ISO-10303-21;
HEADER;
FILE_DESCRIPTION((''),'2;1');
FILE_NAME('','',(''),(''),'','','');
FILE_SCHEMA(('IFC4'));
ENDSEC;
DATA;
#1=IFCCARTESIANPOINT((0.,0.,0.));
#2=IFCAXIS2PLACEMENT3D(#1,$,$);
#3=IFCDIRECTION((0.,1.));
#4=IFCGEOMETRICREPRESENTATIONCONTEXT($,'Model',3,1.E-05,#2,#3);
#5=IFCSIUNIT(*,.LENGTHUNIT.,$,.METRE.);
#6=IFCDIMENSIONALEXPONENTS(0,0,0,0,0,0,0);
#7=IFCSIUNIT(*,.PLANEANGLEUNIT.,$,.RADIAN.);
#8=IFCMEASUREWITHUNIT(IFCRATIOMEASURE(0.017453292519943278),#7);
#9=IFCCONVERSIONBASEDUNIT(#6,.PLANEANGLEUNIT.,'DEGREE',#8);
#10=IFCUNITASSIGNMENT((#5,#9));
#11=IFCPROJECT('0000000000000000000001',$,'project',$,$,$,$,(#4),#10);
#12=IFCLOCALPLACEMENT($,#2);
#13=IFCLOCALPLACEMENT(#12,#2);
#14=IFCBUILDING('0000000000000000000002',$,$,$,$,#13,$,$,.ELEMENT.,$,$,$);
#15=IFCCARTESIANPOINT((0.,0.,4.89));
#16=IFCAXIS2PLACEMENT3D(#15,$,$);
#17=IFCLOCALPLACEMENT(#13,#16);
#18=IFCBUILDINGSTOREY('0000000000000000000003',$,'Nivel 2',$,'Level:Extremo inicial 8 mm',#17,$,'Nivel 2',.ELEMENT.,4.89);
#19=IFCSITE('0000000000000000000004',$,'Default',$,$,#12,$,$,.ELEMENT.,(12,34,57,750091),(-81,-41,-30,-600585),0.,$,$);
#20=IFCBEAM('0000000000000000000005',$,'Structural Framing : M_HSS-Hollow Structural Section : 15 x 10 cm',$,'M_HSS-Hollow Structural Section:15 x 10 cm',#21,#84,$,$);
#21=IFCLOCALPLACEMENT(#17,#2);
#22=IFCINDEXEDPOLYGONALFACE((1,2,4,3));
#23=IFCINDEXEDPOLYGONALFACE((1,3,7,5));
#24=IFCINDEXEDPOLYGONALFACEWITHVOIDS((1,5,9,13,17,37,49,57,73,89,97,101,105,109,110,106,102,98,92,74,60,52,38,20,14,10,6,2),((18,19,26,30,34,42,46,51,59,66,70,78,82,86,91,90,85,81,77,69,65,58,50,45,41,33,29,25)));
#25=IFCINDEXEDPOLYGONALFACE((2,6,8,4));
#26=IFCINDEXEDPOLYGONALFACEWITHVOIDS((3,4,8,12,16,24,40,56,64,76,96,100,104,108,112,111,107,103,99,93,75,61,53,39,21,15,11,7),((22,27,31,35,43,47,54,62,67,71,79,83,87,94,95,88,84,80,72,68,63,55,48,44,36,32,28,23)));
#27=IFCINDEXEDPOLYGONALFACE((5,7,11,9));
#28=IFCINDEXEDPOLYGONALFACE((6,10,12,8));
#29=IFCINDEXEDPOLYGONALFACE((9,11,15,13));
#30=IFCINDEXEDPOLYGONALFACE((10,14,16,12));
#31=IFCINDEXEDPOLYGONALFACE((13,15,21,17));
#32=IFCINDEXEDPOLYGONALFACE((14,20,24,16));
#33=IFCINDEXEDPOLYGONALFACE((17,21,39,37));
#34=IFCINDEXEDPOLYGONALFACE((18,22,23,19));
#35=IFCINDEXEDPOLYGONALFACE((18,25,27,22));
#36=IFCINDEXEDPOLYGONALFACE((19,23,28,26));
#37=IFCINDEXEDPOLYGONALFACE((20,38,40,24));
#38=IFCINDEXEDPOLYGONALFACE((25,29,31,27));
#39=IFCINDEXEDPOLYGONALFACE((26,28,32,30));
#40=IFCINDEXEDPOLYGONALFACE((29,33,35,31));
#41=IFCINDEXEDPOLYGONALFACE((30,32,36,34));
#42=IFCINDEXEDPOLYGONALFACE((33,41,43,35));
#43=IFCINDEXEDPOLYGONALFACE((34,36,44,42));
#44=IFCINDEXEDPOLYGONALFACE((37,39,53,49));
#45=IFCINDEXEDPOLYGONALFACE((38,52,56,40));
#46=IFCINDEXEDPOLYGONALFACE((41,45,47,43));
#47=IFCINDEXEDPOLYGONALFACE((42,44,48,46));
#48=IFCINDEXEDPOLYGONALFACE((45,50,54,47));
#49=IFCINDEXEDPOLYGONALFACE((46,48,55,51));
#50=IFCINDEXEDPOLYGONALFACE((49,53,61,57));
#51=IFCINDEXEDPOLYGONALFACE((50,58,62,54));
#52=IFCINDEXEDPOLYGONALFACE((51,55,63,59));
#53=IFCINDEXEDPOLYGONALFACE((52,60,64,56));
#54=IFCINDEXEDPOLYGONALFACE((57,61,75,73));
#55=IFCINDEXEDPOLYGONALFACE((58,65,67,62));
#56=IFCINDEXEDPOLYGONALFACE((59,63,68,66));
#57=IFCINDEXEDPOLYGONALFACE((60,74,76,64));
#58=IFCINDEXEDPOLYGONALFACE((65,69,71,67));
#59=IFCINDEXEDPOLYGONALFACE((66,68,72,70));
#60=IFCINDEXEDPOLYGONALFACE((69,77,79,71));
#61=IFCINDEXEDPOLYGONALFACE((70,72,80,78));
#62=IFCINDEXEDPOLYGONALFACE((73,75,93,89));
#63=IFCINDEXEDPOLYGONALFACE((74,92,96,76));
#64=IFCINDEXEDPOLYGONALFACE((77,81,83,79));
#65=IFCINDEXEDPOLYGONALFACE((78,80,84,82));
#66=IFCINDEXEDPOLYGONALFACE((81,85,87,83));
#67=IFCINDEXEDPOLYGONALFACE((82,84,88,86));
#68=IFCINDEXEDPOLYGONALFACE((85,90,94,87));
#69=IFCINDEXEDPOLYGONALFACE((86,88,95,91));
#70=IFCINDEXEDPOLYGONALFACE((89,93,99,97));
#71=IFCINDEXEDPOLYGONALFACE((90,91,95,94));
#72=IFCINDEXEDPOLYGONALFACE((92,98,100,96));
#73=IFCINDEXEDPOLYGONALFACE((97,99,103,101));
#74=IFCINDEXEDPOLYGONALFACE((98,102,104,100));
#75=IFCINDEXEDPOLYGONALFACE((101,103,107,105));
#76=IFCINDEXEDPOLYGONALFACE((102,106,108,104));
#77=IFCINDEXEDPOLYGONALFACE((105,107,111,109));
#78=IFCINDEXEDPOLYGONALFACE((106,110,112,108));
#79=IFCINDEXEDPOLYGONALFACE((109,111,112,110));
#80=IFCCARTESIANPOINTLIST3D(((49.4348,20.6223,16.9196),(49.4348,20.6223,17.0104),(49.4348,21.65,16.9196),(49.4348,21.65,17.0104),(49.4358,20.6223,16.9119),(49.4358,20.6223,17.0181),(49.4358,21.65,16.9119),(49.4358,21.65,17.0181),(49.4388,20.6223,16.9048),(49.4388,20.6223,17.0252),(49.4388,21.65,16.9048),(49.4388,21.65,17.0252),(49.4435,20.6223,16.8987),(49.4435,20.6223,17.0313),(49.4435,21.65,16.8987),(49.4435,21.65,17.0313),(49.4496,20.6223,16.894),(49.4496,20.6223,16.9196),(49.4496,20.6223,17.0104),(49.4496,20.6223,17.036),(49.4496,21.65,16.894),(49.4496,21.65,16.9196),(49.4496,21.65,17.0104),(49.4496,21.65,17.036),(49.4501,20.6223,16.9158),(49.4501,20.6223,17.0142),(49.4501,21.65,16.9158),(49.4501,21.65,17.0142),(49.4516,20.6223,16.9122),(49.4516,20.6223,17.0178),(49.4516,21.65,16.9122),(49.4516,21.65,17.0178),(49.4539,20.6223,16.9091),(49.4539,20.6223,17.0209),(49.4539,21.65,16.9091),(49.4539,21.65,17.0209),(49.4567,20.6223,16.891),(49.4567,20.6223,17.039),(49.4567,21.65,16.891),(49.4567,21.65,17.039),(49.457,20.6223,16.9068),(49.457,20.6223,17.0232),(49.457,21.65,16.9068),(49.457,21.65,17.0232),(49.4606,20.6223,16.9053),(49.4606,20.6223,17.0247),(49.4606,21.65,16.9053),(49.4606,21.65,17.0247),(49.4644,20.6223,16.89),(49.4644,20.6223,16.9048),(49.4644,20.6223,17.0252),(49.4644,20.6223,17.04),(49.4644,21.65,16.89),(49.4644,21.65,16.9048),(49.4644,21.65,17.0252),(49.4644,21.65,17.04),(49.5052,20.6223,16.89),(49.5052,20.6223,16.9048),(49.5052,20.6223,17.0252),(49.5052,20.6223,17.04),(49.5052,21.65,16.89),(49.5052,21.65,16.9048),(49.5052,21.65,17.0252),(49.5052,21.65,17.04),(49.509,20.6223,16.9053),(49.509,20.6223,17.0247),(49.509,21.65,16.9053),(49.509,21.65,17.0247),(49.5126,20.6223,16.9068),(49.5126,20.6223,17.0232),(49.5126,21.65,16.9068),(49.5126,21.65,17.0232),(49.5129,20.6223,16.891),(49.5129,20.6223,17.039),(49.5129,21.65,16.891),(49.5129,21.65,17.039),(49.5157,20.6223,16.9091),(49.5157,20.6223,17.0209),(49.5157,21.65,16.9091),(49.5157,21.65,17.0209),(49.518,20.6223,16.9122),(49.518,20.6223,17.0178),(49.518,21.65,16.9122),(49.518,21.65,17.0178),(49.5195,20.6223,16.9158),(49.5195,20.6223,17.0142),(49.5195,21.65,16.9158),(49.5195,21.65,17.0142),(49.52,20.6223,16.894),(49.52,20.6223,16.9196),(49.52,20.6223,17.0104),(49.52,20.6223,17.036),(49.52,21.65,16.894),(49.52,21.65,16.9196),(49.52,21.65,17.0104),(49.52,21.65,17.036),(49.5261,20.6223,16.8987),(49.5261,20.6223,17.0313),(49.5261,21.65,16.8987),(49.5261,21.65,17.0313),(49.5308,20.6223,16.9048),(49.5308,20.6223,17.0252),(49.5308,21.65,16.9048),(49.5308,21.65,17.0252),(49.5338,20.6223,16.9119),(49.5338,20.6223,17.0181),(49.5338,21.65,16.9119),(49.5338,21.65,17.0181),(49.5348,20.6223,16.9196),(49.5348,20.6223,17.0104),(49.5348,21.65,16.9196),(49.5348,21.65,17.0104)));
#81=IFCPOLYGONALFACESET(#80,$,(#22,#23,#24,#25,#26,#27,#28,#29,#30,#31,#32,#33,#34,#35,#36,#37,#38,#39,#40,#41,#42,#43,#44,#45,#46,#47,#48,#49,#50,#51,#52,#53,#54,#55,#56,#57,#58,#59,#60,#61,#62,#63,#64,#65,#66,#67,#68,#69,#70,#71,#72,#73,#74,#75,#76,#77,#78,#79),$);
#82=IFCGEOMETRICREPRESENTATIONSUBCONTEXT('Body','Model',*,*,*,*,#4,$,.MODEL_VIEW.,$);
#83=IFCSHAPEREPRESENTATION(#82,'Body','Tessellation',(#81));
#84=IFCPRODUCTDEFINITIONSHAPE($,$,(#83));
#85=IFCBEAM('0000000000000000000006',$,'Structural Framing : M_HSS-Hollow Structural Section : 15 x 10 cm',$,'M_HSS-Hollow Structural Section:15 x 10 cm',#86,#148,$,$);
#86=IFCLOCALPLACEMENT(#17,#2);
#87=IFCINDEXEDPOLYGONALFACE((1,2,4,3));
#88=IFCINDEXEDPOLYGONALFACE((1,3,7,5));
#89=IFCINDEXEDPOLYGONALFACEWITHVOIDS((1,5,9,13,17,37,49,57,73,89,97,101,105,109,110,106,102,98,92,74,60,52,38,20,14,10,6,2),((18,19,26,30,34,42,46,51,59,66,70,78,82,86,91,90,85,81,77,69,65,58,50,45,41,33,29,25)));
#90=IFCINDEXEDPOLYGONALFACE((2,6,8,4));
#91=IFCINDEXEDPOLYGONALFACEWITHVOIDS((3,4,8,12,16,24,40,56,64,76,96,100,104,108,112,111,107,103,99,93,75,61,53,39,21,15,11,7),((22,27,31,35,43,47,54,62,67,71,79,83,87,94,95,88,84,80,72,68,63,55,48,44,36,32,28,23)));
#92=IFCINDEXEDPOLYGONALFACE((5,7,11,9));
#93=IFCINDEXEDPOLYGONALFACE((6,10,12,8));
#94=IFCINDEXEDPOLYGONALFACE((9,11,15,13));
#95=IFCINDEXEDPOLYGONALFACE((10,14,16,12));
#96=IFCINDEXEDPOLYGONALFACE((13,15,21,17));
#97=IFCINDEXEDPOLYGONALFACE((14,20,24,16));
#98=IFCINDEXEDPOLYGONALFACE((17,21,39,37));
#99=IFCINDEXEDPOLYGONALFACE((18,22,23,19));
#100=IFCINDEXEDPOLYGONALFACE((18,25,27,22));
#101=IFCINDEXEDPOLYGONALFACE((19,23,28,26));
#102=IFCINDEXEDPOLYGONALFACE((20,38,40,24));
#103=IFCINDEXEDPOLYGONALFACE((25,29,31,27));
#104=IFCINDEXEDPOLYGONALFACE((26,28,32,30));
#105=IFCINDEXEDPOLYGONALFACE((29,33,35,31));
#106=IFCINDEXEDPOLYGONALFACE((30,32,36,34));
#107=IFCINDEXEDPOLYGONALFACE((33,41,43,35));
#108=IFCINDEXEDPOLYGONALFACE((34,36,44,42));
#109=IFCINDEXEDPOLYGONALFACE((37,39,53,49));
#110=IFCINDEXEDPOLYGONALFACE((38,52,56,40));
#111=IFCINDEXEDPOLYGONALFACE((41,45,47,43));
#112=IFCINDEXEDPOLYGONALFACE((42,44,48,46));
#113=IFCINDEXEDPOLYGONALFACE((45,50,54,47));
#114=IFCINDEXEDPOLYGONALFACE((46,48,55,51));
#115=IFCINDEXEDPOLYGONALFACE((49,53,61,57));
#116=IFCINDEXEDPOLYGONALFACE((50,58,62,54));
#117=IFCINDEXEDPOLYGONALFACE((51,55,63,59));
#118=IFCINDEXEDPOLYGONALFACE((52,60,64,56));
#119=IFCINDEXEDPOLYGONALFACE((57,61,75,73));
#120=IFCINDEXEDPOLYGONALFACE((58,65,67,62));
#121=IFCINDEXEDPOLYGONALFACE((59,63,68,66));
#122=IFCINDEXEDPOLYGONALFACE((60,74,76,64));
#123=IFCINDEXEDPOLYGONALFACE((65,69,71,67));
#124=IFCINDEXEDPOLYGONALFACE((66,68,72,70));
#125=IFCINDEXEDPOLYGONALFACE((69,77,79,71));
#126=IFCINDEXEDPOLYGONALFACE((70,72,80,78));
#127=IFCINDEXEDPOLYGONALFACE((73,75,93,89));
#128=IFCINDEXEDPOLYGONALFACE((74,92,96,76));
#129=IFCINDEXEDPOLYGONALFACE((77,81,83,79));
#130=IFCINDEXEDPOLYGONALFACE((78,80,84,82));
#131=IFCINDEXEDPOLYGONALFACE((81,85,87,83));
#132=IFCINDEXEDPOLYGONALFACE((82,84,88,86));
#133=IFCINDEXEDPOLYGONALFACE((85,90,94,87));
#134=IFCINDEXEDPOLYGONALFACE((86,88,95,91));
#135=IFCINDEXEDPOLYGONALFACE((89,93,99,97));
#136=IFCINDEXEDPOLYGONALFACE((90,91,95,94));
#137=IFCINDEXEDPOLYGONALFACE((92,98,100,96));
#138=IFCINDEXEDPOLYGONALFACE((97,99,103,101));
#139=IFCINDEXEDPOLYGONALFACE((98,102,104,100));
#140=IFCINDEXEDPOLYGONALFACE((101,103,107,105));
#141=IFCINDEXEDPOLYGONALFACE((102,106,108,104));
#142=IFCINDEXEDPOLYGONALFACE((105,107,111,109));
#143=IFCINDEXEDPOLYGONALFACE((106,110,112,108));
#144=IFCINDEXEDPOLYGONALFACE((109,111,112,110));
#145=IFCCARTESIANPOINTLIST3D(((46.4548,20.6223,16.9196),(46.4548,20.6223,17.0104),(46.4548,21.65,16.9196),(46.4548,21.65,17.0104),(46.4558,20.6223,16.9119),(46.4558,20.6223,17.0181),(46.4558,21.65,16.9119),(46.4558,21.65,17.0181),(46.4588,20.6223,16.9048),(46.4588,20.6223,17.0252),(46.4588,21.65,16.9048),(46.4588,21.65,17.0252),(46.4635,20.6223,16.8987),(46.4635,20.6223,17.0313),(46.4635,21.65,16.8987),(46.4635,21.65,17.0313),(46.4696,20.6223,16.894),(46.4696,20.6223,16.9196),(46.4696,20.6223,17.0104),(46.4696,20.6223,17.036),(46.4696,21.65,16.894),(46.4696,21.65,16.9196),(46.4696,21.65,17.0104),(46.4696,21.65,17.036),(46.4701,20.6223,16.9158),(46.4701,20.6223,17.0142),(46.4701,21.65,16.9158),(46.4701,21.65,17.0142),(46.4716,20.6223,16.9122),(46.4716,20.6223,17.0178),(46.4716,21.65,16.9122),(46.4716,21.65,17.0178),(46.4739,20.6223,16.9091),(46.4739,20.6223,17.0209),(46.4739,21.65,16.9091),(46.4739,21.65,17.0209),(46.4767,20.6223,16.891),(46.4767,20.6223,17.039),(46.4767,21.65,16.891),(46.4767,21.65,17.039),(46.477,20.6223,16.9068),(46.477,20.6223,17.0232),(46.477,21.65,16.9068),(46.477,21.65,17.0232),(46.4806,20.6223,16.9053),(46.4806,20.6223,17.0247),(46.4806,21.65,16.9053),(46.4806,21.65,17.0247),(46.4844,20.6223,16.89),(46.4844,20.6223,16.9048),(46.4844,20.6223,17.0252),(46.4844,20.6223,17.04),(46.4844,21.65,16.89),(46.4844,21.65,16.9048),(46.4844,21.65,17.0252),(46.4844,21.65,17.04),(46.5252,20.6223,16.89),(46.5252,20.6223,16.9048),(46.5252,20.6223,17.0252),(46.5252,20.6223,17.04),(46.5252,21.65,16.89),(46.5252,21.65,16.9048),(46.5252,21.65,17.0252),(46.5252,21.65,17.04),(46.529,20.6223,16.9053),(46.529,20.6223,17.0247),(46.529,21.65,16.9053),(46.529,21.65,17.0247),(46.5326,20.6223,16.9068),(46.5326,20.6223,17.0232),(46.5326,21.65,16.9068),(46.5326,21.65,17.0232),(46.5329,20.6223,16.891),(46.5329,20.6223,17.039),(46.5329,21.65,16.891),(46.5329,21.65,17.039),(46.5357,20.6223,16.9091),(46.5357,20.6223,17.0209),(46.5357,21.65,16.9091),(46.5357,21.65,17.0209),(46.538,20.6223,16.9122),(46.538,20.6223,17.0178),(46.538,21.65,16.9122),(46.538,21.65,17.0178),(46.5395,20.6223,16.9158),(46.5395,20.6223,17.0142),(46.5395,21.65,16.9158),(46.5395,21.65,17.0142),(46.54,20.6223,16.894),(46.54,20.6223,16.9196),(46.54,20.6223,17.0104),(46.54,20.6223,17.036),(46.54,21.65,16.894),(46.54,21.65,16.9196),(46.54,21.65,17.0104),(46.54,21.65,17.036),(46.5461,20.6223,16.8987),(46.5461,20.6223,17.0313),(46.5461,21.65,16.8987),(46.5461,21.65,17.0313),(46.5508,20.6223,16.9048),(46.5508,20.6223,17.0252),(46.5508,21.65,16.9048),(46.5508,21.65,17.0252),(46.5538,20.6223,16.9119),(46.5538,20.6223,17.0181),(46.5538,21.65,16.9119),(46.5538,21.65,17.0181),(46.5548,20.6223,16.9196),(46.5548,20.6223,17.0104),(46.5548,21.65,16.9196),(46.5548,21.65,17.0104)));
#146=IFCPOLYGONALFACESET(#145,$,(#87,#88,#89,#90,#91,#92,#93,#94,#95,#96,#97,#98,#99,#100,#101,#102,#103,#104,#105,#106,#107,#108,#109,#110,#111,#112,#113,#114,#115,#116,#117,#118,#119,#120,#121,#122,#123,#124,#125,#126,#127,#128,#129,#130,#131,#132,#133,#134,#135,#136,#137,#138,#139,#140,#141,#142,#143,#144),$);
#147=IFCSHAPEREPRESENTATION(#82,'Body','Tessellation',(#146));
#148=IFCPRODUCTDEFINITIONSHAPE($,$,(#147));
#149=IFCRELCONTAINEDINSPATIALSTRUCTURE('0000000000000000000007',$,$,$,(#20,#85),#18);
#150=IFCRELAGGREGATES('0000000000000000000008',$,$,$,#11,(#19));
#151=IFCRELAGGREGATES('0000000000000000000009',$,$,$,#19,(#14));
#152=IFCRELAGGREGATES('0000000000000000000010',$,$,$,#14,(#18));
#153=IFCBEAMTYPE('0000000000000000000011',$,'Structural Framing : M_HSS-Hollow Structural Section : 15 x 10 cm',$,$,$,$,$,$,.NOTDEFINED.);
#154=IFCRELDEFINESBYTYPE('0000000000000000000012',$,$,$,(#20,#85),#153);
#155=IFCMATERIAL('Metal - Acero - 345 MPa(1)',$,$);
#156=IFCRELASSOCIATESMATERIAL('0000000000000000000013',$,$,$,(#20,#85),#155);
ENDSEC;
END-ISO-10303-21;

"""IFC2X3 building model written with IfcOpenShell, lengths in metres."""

from ifc_helpers import new_model, entity, si_unit, converted_unit, direction, frame, frame_2d, origin, place, context, subcontext, project, spatial, polyline, circle_curve, parameter, trimmed, segment, composite_curve, outline, extrude, material, type_object, element, save


model = new_model("IFC2X3")

# Units and contexts
model_context = context("Model", 3, precision=1e-05, world=origin(), true_north=direction((0.0, 1.0)))
body_context = subcontext(model_context, "Body", "Model", "MODEL_VIEW")
ifc_project = project(units=[si_unit("LENGTHUNIT", "METRE"), converted_unit("PLANEANGLEUNIT", "DEGREE", entity("IfcRatioMeasure", 0.017453292519943278), si_unit("PLANEANGLEUNIT", "RADIAN"), dimensions=[0, 0, 0, 0, 0, 0, 0])], contexts=[model_context])

# Site, building, storey
site_placement = place(None, origin())
site = spatial("IfcSite", under=ifc_project, at=site_placement, Name="Default", CompositionType="ELEMENT", RefLatitude=(12, 34, 57, 750091), RefLongitude=(-81, -41, -30, -600585), RefElevation=0.0)
building_placement = place(site_placement, origin())
building = spatial("IfcBuilding", under=site, at=building_placement, CompositionType="ELEMENT")
storey_placement = place(building_placement, frame((0.0, 0.0, 4.89)))
storey = spatial("IfcBuildingStorey", under=building, at=storey_placement, Name="Nivel 2", ObjectType="Level:Extremo inicial 8 mm", LongName="Nivel 2", CompositionType="ELEMENT", Elevation=4.89)

# Shared definitions
ifc_material_1 = material(Name="Metal - Acero - 345 MPa(1)")

# Beams
beam_type_1 = type_object("IfcBeamType", Name="Structural Framing : M_HSS-Hollow Structural Section : 15 x 10 cm", PredefinedType="NOTDEFINED")
beam_1_placement = place(storey_placement, frame((49.4848, 21.95, 17.04), z_axis=(0.0, 0.0, 1.0), x_axis=(0.0, -1.0, 0.0)))
element("IfcBeam", 1, at=beam_1_placement, inside=storey, type_object=beam_type_1, material=ifc_material_1, Name="Structural Framing : M_HSS-Hollow Structural Section : 15 x 10 cm", ObjectType="M_HSS-Hollow Structural Section:15 x 10 cm", context=body_context, shape_type="SweptSolid", body=[
    extrude(outline(composite_curve([segment(trimmed(circle_curve(frame_2d((-0.0204, -0.0454), x_axis=(1.0, 0.0)), 0.0296), [parameter(180.0)], [parameter(270.0)], True, "PARAMETER"), True, "CONTINUOUS"), segment(polyline([(-0.0204, -0.075), (0.0204, -0.075)]), True, "CONTINUOUS"), segment(trimmed(circle_curve(frame_2d((0.0204, -0.0454), x_axis=(1.0, 0.0)), 0.0296), [parameter(270.0)], [parameter(0.0)], True, "PARAMETER"), True, "CONTINUOUS"), segment(polyline([(0.05, -0.0454), (0.05, 0.0454)]), True, "CONTINUOUS"), segment(trimmed(circle_curve(frame_2d((0.0204, 0.0454), x_axis=(1.0, 0.0)), 0.0296), [parameter(360.0)], [parameter(90.0)], True, "PARAMETER"), True, "CONTINUOUS"), segment(polyline([(0.0204, 0.075), (-0.0204, 0.075)]), True, "CONTINUOUS"), segment(trimmed(circle_curve(frame_2d((-0.0204, 0.0454), x_axis=(1.0, 0.0)), 0.0296), [parameter(90.0)], [parameter(180.0)], True, "PARAMETER"), True, "CONTINUOUS"), segment(polyline([(-0.05, 0.0454), (-0.05, -0.0454)]), True, "CONTINUOUS")], self_intersect=False), holes=[composite_curve([segment(polyline([(0.0204, -0.0602), (-0.0204, -0.0602)]), True, "CONTINUOUS"), segment(trimmed(circle_curve(frame_2d((-0.0204, -0.0454), x_axis=(1.0, 0.0)), 0.0148), [parameter(180.0)], [parameter(270.0)], True, "PARAMETER"), False, "CONTINUOUS"), segment(polyline([(-0.0352, -0.0454), (-0.0352, 0.0454)]), True, "CONTINUOUS"), segment(trimmed(circle_curve(frame_2d((-0.0204, 0.0454), x_axis=(1.0, 0.0)), 0.0148), [parameter(90.0)], [parameter(180.0)], True, "PARAMETER"), False, "CONTINUOUS"), segment(polyline([(-0.0204, 0.0602), (0.0204, 0.0602)]), True, "CONTINUOUS"), segment(trimmed(circle_curve(frame_2d((0.0204, 0.0454), x_axis=(1.0, 0.0)), 0.0148), [parameter(0.0)], [parameter(90.0)], True, "PARAMETER"), False, "CONTINUOUS"), segment(polyline([(0.0352, 0.0454), (0.0352, -0.0454)]), True, "CONTINUOUS"), segment(trimmed(circle_curve(frame_2d((0.0204, -0.0454), x_axis=(1.0, 0.0)), 0.0148), [parameter(270.0)], [parameter(0.0)], True, "PARAMETER"), False, "CONTINUOUS")], self_intersect=False)]), frame((0.3, 0.0, -0.075), z_axis=(1.0, 0.0, 0.0), x_axis=(0.0, -1.0, 0.0)), (0.0, 0.0, 1.0), 1.0277),
])
beam_2_placement = place(storey_placement, frame((46.5048, 21.95, 17.04), z_axis=(0.0, 0.0, 1.0), x_axis=(0.0, -1.0, 0.0)))
element("IfcBeam", 2, at=beam_2_placement, inside=storey, type_object=beam_type_1, material=ifc_material_1, Name="Structural Framing : M_HSS-Hollow Structural Section : 15 x 10 cm", ObjectType="M_HSS-Hollow Structural Section:15 x 10 cm", context=body_context, shape_type="SweptSolid", body=[
    extrude(outline(composite_curve([segment(trimmed(circle_curve(frame_2d((-0.0204, -0.0454), x_axis=(1.0, 0.0)), 0.0296), [parameter(180.0)], [parameter(270.0)], True, "PARAMETER"), True, "CONTINUOUS"), segment(polyline([(-0.0204, -0.075), (0.0204, -0.075)]), True, "CONTINUOUS"), segment(trimmed(circle_curve(frame_2d((0.0204, -0.0454), x_axis=(1.0, 0.0)), 0.0296), [parameter(270.0)], [parameter(0.0)], True, "PARAMETER"), True, "CONTINUOUS"), segment(polyline([(0.05, -0.0454), (0.05, 0.0454)]), True, "CONTINUOUS"), segment(trimmed(circle_curve(frame_2d((0.0204, 0.0454), x_axis=(1.0, 0.0)), 0.0296), [parameter(360.0)], [parameter(90.0)], True, "PARAMETER"), True, "CONTINUOUS"), segment(polyline([(0.0204, 0.075), (-0.0204, 0.075)]), True, "CONTINUOUS"), segment(trimmed(circle_curve(frame_2d((-0.0204, 0.0454), x_axis=(1.0, 0.0)), 0.0296), [parameter(90.0)], [parameter(180.0)], True, "PARAMETER"), True, "CONTINUOUS"), segment(polyline([(-0.05, 0.0454), (-0.05, -0.0454)]), True, "CONTINUOUS")], self_intersect=False), holes=[composite_curve([segment(polyline([(0.0204, -0.0602), (-0.0204, -0.0602)]), True, "CONTINUOUS"), segment(trimmed(circle_curve(frame_2d((-0.0204, -0.0454), x_axis=(1.0, 0.0)), 0.0148), [parameter(180.0)], [parameter(270.0)], True, "PARAMETER"), False, "CONTINUOUS"), segment(polyline([(-0.0352, -0.0454), (-0.0352, 0.0454)]), True, "CONTINUOUS"), segment(trimmed(circle_curve(frame_2d((-0.0204, 0.0454), x_axis=(1.0, 0.0)), 0.0148), [parameter(90.0)], [parameter(180.0)], True, "PARAMETER"), False, "CONTINUOUS"), segment(polyline([(-0.0204, 0.0602), (0.0204, 0.0602)]), True, "CONTINUOUS"), segment(trimmed(circle_curve(frame_2d((0.0204, 0.0454), x_axis=(1.0, 0.0)), 0.0148), [parameter(0.0)], [parameter(90.0)], True, "PARAMETER"), False, "CONTINUOUS"), segment(polyline([(0.0352, 0.0454), (0.0352, -0.0454)]), True, "CONTINUOUS"), segment(trimmed(circle_curve(frame_2d((0.0204, -0.0454), x_axis=(1.0, 0.0)), 0.0148), [parameter(270.0)], [parameter(0.0)], True, "PARAMETER"), False, "CONTINUOUS")], self_intersect=False)]), frame((0.3, 0.0, -0.075), z_axis=(1.0, 0.0, 0.0), x_axis=(0.0, -1.0, 0.0)), (0.0, 0.0, 1.0), 1.0277),
])

save(model, "model.ifc")
